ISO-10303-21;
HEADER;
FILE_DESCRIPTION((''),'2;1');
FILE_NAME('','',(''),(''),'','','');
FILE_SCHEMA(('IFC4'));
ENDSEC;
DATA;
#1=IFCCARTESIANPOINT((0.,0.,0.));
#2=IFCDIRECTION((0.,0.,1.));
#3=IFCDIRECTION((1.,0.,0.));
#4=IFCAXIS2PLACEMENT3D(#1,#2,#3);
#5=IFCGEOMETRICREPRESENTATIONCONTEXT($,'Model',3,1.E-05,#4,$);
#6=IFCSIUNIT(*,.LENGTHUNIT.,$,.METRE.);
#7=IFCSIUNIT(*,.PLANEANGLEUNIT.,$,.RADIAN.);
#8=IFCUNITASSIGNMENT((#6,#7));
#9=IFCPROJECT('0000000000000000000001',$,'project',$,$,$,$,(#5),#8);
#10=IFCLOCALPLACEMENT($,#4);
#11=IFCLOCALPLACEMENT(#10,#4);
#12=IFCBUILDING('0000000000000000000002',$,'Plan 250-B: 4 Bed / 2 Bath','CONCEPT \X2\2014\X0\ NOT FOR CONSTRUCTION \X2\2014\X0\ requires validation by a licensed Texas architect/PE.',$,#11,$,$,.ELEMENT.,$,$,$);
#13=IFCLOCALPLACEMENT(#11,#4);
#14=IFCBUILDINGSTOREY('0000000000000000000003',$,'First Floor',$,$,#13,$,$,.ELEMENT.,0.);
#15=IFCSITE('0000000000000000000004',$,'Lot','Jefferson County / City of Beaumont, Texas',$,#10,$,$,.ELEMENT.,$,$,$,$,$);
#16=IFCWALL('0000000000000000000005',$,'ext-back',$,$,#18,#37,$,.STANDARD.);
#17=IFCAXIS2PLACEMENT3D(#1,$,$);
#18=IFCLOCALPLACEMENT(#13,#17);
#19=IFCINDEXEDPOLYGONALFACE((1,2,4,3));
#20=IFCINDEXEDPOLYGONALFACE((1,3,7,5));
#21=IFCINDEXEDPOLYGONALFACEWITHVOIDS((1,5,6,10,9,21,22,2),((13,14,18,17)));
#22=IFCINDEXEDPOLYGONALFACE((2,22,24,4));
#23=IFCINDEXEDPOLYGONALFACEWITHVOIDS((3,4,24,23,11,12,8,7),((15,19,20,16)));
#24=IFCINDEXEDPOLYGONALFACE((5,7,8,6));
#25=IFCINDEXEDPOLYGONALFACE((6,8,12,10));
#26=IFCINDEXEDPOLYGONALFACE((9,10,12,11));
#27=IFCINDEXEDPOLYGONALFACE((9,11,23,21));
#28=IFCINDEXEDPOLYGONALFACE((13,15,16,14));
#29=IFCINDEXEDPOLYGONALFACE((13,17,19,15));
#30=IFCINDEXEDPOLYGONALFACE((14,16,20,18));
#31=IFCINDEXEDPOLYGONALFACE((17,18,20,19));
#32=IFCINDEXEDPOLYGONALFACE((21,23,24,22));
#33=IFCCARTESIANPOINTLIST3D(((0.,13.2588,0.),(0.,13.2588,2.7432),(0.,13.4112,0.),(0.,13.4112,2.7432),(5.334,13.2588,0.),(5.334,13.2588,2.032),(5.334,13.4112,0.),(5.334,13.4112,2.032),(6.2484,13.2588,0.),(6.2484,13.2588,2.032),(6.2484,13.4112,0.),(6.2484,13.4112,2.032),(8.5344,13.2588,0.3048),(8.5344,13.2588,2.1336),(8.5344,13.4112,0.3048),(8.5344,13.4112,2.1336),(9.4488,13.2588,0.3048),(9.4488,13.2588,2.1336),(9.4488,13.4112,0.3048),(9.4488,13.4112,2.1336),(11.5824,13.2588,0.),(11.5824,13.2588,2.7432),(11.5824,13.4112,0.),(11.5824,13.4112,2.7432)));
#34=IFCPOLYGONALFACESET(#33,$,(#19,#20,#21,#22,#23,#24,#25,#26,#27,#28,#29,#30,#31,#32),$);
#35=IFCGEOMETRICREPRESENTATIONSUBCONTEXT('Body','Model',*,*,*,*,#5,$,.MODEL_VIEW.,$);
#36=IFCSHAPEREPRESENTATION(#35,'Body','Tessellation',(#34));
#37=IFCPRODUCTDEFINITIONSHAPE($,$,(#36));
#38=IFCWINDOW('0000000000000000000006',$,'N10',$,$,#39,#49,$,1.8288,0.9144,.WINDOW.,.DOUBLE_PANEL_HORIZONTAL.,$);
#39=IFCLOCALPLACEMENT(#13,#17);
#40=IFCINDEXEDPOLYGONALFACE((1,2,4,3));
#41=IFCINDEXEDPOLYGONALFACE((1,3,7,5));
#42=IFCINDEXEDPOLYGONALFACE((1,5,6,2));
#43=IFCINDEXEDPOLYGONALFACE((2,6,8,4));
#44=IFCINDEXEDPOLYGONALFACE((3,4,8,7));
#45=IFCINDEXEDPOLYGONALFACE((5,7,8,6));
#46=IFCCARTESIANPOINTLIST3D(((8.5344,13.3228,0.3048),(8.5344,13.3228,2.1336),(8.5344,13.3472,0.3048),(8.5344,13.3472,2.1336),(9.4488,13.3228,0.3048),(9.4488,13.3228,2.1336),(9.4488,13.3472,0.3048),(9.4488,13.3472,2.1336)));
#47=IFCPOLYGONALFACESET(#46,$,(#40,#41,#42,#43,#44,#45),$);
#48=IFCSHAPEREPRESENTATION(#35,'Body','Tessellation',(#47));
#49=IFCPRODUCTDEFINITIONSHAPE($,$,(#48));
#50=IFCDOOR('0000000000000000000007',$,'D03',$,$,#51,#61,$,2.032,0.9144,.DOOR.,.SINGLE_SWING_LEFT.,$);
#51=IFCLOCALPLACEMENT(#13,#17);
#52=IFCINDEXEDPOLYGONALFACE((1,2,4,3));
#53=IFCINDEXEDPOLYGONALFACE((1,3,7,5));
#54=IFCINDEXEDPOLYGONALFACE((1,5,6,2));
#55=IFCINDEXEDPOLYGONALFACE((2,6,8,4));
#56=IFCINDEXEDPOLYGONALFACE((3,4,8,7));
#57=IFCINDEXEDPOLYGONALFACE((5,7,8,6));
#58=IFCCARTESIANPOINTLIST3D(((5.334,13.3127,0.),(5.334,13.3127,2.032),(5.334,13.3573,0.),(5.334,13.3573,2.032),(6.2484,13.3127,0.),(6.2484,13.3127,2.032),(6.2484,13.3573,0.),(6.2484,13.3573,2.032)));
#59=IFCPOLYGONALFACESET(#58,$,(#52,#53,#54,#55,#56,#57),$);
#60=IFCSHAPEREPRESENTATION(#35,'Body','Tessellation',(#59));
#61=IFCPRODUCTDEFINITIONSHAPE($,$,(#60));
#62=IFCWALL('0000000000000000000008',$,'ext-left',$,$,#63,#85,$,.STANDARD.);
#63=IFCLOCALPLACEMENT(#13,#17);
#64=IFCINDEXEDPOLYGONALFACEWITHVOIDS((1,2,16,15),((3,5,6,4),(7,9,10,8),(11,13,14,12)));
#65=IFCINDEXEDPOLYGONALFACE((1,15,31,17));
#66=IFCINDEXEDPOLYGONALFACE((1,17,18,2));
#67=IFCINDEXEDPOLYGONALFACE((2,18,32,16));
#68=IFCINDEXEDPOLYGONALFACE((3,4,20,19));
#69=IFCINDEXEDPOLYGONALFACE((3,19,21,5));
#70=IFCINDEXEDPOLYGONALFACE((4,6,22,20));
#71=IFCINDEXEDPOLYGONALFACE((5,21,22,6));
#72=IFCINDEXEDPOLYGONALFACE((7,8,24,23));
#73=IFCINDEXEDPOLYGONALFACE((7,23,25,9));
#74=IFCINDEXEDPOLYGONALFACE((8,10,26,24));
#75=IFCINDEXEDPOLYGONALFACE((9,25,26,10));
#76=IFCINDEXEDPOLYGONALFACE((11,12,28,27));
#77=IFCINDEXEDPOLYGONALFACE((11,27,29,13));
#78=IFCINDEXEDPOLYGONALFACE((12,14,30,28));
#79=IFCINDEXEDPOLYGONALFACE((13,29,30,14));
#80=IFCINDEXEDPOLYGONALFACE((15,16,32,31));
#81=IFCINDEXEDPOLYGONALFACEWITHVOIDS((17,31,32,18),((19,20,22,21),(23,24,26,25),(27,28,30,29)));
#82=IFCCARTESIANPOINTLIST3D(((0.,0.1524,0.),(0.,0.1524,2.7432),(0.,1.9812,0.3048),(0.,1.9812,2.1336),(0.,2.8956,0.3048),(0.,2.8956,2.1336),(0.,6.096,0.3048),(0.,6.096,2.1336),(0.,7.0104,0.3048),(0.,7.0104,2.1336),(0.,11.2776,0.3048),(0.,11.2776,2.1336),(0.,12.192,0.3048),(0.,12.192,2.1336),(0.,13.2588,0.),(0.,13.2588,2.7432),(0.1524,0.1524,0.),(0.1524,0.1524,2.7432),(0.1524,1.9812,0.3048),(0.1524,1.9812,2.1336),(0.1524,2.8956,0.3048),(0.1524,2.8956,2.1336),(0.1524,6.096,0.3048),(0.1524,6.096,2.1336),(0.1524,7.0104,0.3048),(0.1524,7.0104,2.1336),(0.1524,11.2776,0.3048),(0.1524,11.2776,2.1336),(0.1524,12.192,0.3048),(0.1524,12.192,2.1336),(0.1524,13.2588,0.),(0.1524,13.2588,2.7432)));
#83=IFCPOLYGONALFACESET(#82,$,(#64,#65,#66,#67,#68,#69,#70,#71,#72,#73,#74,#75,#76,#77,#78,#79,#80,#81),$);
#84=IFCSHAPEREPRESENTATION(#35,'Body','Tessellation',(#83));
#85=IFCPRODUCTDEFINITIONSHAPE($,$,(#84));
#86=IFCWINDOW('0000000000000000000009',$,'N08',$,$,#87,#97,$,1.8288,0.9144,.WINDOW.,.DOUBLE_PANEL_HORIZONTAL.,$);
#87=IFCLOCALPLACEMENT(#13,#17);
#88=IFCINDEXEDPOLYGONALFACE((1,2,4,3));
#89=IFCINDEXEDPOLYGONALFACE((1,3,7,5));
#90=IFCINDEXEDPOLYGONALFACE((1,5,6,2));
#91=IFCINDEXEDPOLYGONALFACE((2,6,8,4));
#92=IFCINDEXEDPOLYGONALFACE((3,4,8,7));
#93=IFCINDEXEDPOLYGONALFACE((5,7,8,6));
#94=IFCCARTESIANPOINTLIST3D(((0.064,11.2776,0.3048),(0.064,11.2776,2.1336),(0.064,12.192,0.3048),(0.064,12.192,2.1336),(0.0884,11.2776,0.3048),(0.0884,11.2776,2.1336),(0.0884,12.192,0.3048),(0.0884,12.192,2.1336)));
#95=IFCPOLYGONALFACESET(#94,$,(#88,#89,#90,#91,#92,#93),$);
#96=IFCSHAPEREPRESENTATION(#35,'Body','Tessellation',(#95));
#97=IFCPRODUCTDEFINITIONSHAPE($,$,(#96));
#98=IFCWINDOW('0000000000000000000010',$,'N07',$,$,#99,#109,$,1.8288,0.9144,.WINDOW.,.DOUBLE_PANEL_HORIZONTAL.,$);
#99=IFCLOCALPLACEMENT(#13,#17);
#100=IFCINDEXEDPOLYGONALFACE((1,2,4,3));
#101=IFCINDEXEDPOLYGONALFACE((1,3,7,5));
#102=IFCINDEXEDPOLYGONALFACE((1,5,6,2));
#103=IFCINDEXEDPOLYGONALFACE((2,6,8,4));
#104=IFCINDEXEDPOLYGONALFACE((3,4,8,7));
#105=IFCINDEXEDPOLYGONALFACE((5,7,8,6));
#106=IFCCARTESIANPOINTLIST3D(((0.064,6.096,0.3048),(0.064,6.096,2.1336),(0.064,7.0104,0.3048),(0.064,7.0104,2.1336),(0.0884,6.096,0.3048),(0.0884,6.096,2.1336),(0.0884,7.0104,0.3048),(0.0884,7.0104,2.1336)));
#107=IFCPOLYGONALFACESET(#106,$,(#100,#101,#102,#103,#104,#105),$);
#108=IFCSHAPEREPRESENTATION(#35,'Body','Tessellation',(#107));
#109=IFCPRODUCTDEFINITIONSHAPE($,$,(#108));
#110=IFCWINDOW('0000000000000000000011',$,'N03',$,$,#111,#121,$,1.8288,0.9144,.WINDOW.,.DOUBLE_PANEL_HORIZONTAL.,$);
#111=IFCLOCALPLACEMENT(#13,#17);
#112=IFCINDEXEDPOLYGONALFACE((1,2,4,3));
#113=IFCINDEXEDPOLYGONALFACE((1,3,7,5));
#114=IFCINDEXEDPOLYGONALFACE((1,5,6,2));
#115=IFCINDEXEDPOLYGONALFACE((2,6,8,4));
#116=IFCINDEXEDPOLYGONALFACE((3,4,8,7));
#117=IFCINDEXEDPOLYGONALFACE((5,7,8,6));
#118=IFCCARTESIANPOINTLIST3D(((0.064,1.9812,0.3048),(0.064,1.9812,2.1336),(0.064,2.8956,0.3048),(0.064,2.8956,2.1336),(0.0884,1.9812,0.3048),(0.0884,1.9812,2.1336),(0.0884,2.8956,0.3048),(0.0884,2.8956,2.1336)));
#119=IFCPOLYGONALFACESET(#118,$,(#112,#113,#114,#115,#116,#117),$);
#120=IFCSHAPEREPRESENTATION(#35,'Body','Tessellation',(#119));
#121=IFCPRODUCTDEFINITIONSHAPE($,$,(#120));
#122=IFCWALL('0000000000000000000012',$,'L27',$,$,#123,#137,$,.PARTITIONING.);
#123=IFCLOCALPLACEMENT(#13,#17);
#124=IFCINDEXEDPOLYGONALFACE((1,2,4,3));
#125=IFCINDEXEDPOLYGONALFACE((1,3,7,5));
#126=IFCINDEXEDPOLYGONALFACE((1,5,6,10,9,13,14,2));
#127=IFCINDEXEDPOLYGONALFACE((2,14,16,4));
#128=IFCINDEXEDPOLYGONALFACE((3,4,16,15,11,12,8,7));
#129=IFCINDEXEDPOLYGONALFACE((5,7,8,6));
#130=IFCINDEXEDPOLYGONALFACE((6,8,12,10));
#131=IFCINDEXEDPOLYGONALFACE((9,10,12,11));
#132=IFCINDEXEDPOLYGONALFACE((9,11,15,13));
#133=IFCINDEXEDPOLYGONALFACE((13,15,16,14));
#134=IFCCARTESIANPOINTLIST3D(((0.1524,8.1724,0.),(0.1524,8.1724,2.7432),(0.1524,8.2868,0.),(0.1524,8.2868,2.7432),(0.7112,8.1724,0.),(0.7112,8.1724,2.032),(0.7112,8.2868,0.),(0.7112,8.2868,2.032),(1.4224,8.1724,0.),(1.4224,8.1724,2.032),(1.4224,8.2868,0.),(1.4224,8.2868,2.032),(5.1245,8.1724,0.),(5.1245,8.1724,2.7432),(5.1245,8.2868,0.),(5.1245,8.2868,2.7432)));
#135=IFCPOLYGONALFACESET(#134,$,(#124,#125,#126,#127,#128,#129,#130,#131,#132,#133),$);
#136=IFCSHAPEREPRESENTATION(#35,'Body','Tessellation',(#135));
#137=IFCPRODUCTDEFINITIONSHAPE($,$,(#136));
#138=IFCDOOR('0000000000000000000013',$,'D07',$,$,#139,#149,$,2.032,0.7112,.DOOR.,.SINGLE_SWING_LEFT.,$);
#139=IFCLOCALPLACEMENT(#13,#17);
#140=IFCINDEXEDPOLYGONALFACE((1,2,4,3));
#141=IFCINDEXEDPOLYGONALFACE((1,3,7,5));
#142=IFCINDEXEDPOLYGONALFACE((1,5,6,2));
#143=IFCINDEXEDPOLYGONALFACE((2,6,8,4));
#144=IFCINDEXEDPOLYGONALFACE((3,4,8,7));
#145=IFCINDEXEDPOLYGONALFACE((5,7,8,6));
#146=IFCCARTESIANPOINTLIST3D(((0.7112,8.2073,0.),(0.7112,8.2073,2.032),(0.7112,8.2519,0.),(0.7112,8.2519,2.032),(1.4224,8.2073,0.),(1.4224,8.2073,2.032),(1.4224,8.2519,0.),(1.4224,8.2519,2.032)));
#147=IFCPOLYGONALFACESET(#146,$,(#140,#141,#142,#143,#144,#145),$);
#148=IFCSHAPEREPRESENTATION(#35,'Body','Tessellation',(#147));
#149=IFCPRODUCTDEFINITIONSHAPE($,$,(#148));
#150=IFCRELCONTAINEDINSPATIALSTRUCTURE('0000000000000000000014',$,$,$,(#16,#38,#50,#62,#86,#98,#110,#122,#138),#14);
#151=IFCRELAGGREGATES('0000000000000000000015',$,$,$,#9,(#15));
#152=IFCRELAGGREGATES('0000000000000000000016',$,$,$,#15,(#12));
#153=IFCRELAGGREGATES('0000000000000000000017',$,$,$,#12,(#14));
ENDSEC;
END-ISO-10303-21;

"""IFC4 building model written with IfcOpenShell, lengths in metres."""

from ifc_helpers import new_model, si_unit, frame, frame_2d, origin_with_axes, place, context, subcontext, project, spatial, rectangle, extrude, element, fill, save


model = new_model("IFC4")

# Units and contexts
model_context = context("Model", 3, precision=1e-05, world=origin_with_axes())
body_context = subcontext(model_context, "Body", "Model", "MODEL_VIEW")
ifc_project = project(units=[si_unit("LENGTHUNIT", "METRE"), si_unit("PLANEANGLEUNIT", "RADIAN")], contexts=[model_context])

# Site, building, storey
site_placement = place(None, origin_with_axes())
site = spatial("IfcSite", under=ifc_project, at=site_placement, Name="Lot", Description="Jefferson County / City of Beaumont, Texas", CompositionType="ELEMENT")
building_placement = place(site_placement, origin_with_axes())
building = spatial("IfcBuilding", under=site, at=building_placement, Name="Plan 250-B: 4 Bed / 2 Bath", Description="CONCEPT — NOT FOR CONSTRUCTION — requires validation by a licensed Texas architect/PE.", CompositionType="ELEMENT")
storey_placement = place(building_placement, origin_with_axes())
storey = spatial("IfcBuildingStorey", under=building, at=storey_placement, Name="First Floor", CompositionType="ELEMENT", Elevation=0.0)

# Wall, openings, window, door
wall_1_placement = place(storey_placement, frame((11.5824, 13.335, 0.0), z_axis=(0.0, 0.0, 1.0), x_axis=(-1.0, 0.0, 0.0)))
wall_1 = element("IfcWall", 1, at=wall_1_placement, inside=storey, Name="ext-back", PredefinedType="STANDARD", context=body_context, shape_type="SweptSolid", body=[
    extrude(rectangle(XDim=11.5824, YDim=0.1524, at=frame_2d((5.7912, 0.0), x_axis=(1.0, 0.0))), origin_with_axes(), (0.0, 0.0, 1.0), 2.7432),
])
opening_1_placement = place(wall_1_placement, frame((2.1336, 0.0, 0.3048), z_axis=(0.0, 0.0, 1.0), x_axis=(1.0, 0.0, 0.0)))
opening_1 = element("IfcOpeningElement", 2, at=opening_1_placement, cuts=wall_1, PredefinedType="OPENING", context=body_context, shape_type="SweptSolid", body=[
    extrude(rectangle(XDim=0.9144, YDim=0.1829, at=frame_2d((0.4572, 0.0), x_axis=(1.0, 0.0))), origin_with_axes(), (0.0, 0.0, 1.0), 1.8288),
])
opening_2_placement = place(wall_1_placement, frame((5.334, 0.0, 0.0), z_axis=(0.0, 0.0, 1.0), x_axis=(1.0, 0.0, 0.0)))
opening_2 = element("IfcOpeningElement", 3, at=opening_2_placement, cuts=wall_1, PredefinedType="OPENING", context=body_context, shape_type="SweptSolid", body=[
    extrude(rectangle(XDim=0.9144, YDim=0.1829, at=frame_2d((0.4572, 0.0), x_axis=(1.0, 0.0))), origin_with_axes(), (0.0, 0.0, 1.0), 2.032),
])
window_1_placement = place(opening_1_placement, origin_with_axes())
window_1 = element("IfcWindow", 4, at=window_1_placement, inside=storey, Name="N10", OverallHeight=1.8288, OverallWidth=0.9144, PartitioningType="DOUBLE_PANEL_HORIZONTAL", PredefinedType="WINDOW", context=body_context, shape_type="SweptSolid", body=[
    extrude(rectangle(XDim=0.9144, YDim=0.0244, at=frame_2d((0.4572, 0.0), x_axis=(1.0, 0.0))), origin_with_axes(), (0.0, 0.0, 1.0), 1.8288),
])
fill(opening_1, window_1)
door_1_placement = place(opening_2_placement, origin_with_axes())
door_1 = element("IfcDoor", 5, at=door_1_placement, inside=storey, Name="D03", OperationType="SINGLE_SWING_LEFT", OverallHeight=2.032, OverallWidth=0.9144, PredefinedType="DOOR", context=body_context, shape_type="SweptSolid", body=[
    extrude(rectangle(XDim=0.9144, YDim=0.0445, at=frame_2d((0.4572, 0.0), x_axis=(1.0, 0.0))), origin_with_axes(), (0.0, 0.0, 1.0), 2.032),
])
fill(opening_2, door_1)

# Wall, openings, windows
wall_2_placement = place(storey_placement, frame((0.0762, 13.2588, 0.0), z_axis=(0.0, 0.0, 1.0), x_axis=(0.0, -1.0, 0.0)))
wall_2 = element("IfcWall", 6, at=wall_2_placement, inside=storey, Name="ext-left", PredefinedType="STANDARD", context=body_context, shape_type="SweptSolid", body=[
    extrude(rectangle(XDim=13.1064, YDim=0.1524, at=frame_2d((6.5532, 0.0), x_axis=(1.0, 0.0))), origin_with_axes(), (0.0, 0.0, 1.0), 2.7432),
])
opening_3_placement = place(wall_2_placement, frame((1.0668, 0.0, 0.3048), z_axis=(0.0, 0.0, 1.0), x_axis=(1.0, 0.0, 0.0)))
opening_3 = element("IfcOpeningElement", 7, at=opening_3_placement, cuts=wall_2, PredefinedType="OPENING", context=body_context, shape_type="SweptSolid", body=[
    extrude(rectangle(XDim=0.9144, YDim=0.1829, at=frame_2d((0.4572, 0.0), x_axis=(1.0, 0.0))), origin_with_axes(), (0.0, 0.0, 1.0), 1.8288),
])
opening_4_placement = place(wall_2_placement, frame((6.2484, 0.0, 0.3048), z_axis=(0.0, 0.0, 1.0), x_axis=(1.0, 0.0, 0.0)))
opening_4 = element("IfcOpeningElement", 8, at=opening_4_placement, cuts=wall_2, PredefinedType="OPENING", context=body_context, shape_type="SweptSolid", body=[
    extrude(rectangle(XDim=0.9144, YDim=0.1829, at=frame_2d((0.4572, 0.0), x_axis=(1.0, 0.0))), origin_with_axes(), (0.0, 0.0, 1.0), 1.8288),
])
opening_5_placement = place(wall_2_placement, frame((10.3632, 0.0, 0.3048), z_axis=(0.0, 0.0, 1.0), x_axis=(1.0, 0.0, 0.0)))
opening_5 = element("IfcOpeningElement", 9, at=opening_5_placement, cuts=wall_2, PredefinedType="OPENING", context=body_context, shape_type="SweptSolid", body=[
    extrude(rectangle(XDim=0.9144, YDim=0.1829, at=frame_2d((0.4572, 0.0), x_axis=(1.0, 0.0))), origin_with_axes(), (0.0, 0.0, 1.0), 1.8288),
])
window_2_placement = place(opening_3_placement, origin_with_axes())
window_2 = element("IfcWindow", 10, at=window_2_placement, inside=storey, Name="N08", OverallHeight=1.8288, OverallWidth=0.9144, PartitioningType="DOUBLE_PANEL_HORIZONTAL", PredefinedType="WINDOW", context=body_context, shape_type="SweptSolid", body=[
    extrude(rectangle(XDim=0.9144, YDim=0.0244, at=frame_2d((0.4572, 0.0), x_axis=(1.0, 0.0))), origin_with_axes(), (0.0, 0.0, 1.0), 1.8288),
])
fill(opening_3, window_2)
window_3_placement = place(opening_4_placement, origin_with_axes())
window_3 = element("IfcWindow", 11, at=window_3_placement, inside=storey, Name="N07", OverallHeight=1.8288, OverallWidth=0.9144, PartitioningType="DOUBLE_PANEL_HORIZONTAL", PredefinedType="WINDOW", context=body_context, shape_type="SweptSolid", body=[
    extrude(rectangle(XDim=0.9144, YDim=0.0244, at=frame_2d((0.4572, 0.0), x_axis=(1.0, 0.0))), origin_with_axes(), (0.0, 0.0, 1.0), 1.8288),
])
fill(opening_4, window_3)
window_4_placement = place(opening_5_placement, origin_with_axes())
window_4 = element("IfcWindow", 12, at=window_4_placement, inside=storey, Name="N03", OverallHeight=1.8288, OverallWidth=0.9144, PartitioningType="DOUBLE_PANEL_HORIZONTAL", PredefinedType="WINDOW", context=body_context, shape_type="SweptSolid", body=[
    extrude(rectangle(XDim=0.9144, YDim=0.0244, at=frame_2d((0.4572, 0.0), x_axis=(1.0, 0.0))), origin_with_axes(), (0.0, 0.0, 1.0), 1.8288),
])
fill(opening_5, window_4)

# Wall, opening, door
wall_3_placement = place(storey_placement, frame((0.1524, 8.2296, 0.0), z_axis=(0.0, 0.0, 1.0), x_axis=(1.0, 0.0, 0.0)))
wall_3 = element("IfcWall", 13, at=wall_3_placement, inside=storey, Name="L27", PredefinedType="PARTITIONING", context=body_context, shape_type="SweptSolid", body=[
    extrude(rectangle(XDim=4.9721, YDim=0.1143, at=frame_2d((2.486, 0.0), x_axis=(1.0, 0.0))), origin_with_axes(), (0.0, 0.0, 1.0), 2.7432),
])
opening_6_placement = place(wall_3_placement, frame((0.5588, 0.0, 0.0), z_axis=(0.0, 0.0, 1.0), x_axis=(1.0, 0.0, 0.0)))
opening_6 = element("IfcOpeningElement", 14, at=opening_6_placement, cuts=wall_3, PredefinedType="OPENING", context=body_context, shape_type="SweptSolid", body=[
    extrude(rectangle(XDim=0.7112, YDim=0.1448, at=frame_2d((0.3556, 0.0), x_axis=(1.0, 0.0))), origin_with_axes(), (0.0, 0.0, 1.0), 2.032),
])
door_2_placement = place(opening_6_placement, origin_with_axes())
door_2 = element("IfcDoor", 15, at=door_2_placement, inside=storey, Name="D07", OperationType="SINGLE_SWING_LEFT", OverallHeight=2.032, OverallWidth=0.7112, PredefinedType="DOOR", context=body_context, shape_type="SweptSolid", body=[
    extrude(rectangle(XDim=0.7112, YDim=0.0445, at=frame_2d((0.3556, 0.0), x_axis=(1.0, 0.0))), origin_with_axes(), (0.0, 0.0, 1.0), 2.032),
])
fill(opening_6, door_2)

save(model, "model.ifc")
